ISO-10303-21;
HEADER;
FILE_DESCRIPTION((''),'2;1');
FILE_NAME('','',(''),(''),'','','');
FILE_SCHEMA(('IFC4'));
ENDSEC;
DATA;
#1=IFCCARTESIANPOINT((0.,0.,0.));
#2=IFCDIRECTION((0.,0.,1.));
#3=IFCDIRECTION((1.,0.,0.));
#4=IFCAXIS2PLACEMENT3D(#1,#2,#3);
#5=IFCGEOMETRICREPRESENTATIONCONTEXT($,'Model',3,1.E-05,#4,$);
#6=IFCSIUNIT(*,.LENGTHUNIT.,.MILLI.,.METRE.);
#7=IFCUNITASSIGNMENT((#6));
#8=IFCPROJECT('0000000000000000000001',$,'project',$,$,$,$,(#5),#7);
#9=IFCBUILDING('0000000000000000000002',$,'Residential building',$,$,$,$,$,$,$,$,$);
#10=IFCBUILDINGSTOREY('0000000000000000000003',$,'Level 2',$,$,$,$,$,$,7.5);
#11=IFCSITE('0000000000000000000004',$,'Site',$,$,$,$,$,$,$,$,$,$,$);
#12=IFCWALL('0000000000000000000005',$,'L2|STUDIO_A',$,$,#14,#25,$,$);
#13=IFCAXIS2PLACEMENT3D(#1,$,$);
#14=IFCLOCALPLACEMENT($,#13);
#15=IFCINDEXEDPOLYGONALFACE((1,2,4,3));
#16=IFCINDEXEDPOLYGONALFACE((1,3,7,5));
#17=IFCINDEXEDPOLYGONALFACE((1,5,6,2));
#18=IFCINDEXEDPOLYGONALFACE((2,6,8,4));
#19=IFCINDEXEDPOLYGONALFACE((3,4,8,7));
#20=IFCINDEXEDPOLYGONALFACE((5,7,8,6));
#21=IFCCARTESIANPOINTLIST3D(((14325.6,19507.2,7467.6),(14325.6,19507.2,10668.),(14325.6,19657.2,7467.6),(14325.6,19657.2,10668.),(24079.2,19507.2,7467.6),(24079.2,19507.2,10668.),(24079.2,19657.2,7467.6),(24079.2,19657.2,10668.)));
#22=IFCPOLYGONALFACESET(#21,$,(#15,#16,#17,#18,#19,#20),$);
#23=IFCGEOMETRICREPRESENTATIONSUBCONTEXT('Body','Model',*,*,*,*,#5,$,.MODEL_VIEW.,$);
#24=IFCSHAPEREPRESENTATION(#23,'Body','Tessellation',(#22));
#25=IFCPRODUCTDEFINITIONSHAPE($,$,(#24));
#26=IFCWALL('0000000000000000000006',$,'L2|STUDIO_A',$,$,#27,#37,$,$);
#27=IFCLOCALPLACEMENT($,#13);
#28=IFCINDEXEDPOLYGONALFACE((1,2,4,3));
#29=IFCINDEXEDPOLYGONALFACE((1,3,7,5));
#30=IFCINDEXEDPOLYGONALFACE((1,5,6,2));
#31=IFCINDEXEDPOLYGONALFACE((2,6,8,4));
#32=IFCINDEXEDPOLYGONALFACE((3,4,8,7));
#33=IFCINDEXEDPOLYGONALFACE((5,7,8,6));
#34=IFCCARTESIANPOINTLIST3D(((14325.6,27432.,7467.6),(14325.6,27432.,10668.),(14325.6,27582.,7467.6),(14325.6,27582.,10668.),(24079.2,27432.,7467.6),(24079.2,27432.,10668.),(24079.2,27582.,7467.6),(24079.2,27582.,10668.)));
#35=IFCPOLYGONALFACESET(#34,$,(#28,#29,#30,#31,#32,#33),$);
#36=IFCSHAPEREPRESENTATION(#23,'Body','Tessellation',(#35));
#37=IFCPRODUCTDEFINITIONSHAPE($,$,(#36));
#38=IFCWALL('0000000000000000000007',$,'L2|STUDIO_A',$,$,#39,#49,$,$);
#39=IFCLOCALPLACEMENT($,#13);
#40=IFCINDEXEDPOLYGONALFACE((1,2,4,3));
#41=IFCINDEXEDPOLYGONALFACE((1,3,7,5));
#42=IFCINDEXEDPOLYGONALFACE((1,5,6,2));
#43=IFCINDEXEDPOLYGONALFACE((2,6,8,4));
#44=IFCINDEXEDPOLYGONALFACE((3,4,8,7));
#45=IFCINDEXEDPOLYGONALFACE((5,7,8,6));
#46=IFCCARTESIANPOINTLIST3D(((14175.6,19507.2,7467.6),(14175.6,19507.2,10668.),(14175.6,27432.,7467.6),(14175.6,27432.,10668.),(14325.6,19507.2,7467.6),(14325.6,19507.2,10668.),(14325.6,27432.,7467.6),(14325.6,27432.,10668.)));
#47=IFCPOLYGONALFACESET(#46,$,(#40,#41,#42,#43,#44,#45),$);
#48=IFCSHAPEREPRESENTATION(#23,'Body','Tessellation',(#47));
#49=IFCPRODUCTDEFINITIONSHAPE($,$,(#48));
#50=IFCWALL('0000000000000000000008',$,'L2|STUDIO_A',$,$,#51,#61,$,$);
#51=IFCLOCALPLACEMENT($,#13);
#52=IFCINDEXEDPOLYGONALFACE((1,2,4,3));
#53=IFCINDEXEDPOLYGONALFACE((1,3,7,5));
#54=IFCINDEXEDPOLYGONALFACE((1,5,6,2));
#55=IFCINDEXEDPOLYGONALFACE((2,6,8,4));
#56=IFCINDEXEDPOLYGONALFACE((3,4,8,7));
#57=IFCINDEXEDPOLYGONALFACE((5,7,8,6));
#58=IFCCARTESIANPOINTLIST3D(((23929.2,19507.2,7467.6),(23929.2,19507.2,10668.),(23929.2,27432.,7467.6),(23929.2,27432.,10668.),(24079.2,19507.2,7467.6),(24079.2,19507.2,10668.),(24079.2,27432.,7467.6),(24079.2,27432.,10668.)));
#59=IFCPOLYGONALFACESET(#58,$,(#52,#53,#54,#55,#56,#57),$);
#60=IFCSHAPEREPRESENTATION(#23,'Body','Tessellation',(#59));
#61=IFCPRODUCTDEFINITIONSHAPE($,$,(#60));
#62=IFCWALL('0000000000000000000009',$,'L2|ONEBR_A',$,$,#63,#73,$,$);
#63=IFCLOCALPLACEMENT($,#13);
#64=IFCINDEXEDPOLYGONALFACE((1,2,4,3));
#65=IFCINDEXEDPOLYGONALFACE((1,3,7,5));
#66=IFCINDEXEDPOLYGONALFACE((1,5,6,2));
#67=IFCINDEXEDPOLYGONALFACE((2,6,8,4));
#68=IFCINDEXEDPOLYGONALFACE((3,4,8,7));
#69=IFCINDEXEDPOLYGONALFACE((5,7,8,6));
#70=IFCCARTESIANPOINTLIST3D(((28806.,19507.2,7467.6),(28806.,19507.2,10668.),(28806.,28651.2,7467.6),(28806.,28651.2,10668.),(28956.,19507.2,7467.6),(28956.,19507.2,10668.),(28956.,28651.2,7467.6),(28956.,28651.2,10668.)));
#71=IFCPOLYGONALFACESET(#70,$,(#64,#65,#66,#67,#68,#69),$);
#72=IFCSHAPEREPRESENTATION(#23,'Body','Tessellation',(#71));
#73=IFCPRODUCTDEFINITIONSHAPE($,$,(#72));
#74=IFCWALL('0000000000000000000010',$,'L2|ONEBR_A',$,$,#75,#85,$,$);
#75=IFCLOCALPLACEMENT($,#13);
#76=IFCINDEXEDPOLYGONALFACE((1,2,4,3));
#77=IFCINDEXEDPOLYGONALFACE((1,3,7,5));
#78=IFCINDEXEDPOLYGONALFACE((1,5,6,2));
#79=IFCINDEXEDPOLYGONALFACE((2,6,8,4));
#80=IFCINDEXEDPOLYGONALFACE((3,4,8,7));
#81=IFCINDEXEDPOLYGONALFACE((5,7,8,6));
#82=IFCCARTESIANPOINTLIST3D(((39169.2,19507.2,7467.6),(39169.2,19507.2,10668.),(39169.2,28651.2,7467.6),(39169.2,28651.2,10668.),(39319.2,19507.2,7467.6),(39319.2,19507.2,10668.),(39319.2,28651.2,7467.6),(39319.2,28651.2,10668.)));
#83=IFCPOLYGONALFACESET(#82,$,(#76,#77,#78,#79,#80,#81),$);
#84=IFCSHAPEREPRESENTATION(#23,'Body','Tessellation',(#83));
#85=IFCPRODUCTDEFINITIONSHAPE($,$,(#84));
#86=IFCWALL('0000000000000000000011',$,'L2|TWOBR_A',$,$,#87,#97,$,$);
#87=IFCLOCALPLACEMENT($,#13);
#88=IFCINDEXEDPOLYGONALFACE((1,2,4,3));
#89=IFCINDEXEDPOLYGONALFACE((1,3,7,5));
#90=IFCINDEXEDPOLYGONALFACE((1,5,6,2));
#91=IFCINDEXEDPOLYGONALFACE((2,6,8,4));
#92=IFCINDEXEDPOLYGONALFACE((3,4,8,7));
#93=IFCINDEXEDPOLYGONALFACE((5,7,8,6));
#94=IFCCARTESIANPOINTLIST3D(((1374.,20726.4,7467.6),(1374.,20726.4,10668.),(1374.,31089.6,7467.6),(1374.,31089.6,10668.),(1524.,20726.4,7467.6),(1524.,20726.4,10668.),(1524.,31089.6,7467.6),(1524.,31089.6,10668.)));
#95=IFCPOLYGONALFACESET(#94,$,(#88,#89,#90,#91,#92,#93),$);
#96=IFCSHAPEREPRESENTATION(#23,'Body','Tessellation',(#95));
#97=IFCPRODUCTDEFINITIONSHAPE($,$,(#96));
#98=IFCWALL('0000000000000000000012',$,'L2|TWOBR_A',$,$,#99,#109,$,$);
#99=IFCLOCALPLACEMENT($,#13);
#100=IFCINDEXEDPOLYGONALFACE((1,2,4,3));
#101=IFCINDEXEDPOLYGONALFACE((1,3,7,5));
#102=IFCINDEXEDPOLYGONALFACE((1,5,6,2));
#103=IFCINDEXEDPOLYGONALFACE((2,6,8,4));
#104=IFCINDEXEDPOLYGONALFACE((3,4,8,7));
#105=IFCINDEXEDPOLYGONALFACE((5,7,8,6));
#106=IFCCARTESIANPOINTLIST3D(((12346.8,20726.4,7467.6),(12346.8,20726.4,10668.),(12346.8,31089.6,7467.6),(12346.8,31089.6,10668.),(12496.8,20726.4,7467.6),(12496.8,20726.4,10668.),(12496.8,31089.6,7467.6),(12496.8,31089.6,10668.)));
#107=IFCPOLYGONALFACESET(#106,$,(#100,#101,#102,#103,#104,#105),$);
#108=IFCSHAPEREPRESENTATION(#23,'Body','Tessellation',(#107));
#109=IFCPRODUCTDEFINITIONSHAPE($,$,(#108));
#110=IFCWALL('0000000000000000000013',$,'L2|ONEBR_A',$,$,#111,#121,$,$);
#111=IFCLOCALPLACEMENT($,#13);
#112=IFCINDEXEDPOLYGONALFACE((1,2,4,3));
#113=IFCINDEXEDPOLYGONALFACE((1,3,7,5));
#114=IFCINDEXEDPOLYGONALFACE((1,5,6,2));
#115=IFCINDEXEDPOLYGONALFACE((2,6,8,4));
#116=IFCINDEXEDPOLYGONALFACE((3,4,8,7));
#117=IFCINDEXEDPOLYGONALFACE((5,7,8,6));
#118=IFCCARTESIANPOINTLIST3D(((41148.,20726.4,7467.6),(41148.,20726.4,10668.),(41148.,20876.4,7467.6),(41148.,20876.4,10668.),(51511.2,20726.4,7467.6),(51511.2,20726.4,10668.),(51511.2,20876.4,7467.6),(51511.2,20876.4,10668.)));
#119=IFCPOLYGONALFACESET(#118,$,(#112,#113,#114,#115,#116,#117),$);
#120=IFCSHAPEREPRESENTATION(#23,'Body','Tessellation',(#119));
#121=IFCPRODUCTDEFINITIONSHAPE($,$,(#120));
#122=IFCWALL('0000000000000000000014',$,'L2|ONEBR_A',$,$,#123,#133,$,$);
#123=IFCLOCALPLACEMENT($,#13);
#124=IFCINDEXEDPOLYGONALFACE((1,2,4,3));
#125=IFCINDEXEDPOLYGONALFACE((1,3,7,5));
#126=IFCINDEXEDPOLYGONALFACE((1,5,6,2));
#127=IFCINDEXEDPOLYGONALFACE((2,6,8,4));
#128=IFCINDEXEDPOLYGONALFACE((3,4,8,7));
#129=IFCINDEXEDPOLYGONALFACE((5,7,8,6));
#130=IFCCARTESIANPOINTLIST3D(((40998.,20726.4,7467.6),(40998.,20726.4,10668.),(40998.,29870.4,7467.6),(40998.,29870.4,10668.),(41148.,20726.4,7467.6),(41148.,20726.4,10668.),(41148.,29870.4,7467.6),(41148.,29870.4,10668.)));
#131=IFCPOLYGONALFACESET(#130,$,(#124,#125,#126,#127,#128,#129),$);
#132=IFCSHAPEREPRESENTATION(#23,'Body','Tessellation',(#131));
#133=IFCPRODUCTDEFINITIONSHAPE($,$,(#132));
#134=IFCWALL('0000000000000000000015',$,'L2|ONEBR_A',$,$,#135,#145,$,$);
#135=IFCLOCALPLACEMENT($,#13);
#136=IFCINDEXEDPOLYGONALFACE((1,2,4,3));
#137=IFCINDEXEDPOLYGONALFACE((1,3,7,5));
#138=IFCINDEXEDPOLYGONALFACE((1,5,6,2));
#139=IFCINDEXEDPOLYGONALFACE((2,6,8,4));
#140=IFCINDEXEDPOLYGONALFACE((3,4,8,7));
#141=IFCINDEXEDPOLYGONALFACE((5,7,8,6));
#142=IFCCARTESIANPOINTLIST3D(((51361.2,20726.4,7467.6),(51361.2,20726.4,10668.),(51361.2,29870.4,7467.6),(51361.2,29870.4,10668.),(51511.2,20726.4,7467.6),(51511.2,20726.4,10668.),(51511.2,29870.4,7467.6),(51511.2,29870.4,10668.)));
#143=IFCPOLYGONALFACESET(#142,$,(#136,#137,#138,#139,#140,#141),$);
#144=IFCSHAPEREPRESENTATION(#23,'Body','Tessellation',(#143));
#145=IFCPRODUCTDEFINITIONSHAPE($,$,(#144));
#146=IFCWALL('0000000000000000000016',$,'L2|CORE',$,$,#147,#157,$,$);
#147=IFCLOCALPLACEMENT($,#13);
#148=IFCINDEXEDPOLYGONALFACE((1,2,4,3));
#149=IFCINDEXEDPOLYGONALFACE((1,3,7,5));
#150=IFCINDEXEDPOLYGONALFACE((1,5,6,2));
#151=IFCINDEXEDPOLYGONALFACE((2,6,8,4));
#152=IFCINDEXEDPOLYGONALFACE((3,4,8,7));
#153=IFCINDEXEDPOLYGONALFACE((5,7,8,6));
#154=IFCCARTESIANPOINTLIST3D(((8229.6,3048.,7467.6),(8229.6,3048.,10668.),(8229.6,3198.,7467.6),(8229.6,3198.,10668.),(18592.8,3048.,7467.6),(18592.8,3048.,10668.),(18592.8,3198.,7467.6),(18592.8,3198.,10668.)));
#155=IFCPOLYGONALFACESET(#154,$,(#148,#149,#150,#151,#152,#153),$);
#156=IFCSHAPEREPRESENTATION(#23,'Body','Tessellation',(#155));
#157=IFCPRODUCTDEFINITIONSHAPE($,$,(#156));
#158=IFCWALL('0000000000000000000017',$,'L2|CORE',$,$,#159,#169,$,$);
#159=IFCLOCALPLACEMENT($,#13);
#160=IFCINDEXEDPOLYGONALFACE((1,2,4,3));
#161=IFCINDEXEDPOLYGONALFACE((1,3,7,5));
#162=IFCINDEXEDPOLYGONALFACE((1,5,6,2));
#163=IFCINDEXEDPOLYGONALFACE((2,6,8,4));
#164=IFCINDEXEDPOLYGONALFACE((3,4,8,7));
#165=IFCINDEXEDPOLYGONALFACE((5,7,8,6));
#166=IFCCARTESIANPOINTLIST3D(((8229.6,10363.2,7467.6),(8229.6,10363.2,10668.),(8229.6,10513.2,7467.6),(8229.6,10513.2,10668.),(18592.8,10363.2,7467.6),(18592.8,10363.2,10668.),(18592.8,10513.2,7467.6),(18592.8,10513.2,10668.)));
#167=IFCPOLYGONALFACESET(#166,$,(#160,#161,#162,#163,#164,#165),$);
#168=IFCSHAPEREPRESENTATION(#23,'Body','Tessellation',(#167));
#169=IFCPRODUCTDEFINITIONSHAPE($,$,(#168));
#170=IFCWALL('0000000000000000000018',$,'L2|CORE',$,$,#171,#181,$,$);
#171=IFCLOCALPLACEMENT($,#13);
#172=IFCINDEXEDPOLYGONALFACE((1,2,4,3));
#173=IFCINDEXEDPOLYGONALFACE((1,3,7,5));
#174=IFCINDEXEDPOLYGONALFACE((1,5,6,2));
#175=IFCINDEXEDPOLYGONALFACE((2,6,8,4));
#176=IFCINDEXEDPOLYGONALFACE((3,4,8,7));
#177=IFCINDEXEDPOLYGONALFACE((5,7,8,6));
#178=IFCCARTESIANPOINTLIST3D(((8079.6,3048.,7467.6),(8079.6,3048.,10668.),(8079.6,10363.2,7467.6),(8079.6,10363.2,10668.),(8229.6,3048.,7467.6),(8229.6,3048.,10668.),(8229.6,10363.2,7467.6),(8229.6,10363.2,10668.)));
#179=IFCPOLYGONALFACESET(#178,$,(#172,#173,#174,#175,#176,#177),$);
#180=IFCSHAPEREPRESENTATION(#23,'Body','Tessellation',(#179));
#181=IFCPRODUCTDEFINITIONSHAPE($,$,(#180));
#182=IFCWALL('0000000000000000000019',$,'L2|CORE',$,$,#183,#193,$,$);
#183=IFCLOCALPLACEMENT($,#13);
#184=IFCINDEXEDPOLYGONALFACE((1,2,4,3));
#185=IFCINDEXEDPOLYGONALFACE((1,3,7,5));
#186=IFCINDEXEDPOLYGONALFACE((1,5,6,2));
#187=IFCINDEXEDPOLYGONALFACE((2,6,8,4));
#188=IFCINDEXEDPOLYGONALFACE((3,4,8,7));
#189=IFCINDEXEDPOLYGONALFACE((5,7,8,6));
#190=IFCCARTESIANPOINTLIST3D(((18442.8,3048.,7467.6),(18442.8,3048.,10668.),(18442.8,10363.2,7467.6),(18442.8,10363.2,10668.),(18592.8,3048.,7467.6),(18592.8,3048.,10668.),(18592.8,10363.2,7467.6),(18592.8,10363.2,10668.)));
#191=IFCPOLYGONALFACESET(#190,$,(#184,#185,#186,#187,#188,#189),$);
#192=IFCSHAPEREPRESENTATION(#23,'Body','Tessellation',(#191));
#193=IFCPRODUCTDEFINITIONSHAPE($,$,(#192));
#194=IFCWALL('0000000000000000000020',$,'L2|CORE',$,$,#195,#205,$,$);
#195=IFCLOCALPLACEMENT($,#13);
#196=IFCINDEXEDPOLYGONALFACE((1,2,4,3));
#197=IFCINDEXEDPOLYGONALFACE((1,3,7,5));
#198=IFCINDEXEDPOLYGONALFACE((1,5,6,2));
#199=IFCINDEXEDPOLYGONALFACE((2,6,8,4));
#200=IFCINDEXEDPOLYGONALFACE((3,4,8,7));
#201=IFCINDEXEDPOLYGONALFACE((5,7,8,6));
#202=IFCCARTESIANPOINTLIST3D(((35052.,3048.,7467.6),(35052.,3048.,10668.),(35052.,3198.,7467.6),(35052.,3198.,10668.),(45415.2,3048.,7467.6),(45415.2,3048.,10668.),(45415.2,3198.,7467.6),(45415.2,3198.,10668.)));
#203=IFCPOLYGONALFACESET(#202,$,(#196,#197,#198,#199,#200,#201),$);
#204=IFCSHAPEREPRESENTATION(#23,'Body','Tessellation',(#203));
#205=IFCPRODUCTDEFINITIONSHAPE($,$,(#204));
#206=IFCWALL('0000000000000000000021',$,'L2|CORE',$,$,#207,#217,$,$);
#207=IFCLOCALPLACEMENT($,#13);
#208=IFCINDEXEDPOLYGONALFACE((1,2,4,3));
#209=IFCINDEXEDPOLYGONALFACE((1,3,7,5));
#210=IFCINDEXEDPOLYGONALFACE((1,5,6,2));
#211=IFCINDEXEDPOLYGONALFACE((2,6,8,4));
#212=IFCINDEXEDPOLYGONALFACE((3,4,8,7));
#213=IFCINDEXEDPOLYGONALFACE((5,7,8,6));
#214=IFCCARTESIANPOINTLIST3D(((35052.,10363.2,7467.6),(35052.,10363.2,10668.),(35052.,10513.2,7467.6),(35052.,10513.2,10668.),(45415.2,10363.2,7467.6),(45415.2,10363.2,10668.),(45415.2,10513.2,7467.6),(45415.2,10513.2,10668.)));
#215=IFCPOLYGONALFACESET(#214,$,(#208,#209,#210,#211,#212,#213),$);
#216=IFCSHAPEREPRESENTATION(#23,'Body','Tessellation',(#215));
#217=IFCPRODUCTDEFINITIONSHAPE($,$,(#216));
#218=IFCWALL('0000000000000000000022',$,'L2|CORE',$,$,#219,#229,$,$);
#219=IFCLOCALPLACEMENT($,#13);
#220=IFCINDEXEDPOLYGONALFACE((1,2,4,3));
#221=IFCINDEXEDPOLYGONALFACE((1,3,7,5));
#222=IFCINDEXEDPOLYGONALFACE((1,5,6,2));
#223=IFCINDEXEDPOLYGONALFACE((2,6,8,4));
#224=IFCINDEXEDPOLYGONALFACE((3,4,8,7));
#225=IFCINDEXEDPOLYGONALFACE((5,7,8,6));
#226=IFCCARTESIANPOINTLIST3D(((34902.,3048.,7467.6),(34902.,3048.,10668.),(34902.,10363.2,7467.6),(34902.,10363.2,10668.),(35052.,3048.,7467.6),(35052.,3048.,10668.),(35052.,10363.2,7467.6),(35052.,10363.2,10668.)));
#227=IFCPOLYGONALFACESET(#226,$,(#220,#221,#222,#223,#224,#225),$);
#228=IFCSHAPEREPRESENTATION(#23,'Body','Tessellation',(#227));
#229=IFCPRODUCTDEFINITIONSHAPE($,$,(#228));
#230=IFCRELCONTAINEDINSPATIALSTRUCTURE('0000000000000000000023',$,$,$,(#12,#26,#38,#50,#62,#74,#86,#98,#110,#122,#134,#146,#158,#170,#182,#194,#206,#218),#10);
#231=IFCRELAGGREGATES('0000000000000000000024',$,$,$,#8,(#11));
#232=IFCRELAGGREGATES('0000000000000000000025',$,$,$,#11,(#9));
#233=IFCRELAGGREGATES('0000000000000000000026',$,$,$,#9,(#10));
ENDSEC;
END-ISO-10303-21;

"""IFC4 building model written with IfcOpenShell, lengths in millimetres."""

from ifc_helpers import new_model, si_unit, frame, origin_with_axes, place, context, subcontext, project, spatial, indexed_curve, outline, extrude, element, save


model = new_model("IFC4")

# Units and contexts
model_context = context("Model", 3, precision=1e-05, world=origin_with_axes())
body_context = subcontext(model_context, "Body", "Model", "MODEL_VIEW")
ifc_project = project(units=[si_unit("LENGTHUNIT", "METRE", prefix="MILLI")], contexts=[model_context])

# Site, building, storey
site = spatial("IfcSite", under=ifc_project, Name="Site")
building = spatial("IfcBuilding", under=site, Name="Residential building")
storey = spatial("IfcBuildingStorey", under=building, Name="Level 2", Elevation=7.5)

# Walls
for number, where, z_axis, x_axis, name in (
    (1, (14325.6, 19507.2, 7467.6), (0.0, 0.0, 1.0), (1.0, 0.0, 0.0), "L2|STUDIO_A"),
    (2, (14325.6, 27432.0, 7467.6), (0.0, 0.0, 1.0), (1.0, 0.0, 0.0), "L2|STUDIO_A"),
):
    element("IfcWall", number, at=place(None, frame(where, z_axis=z_axis, x_axis=x_axis)), inside=storey, Name=name, context=body_context, shape_type="SweptSolid", body=[
        extrude(outline(indexed_curve([(0.0, 0.0), (0.0, 150.0), (9753.6, 150.0), (9753.6, 0.0), (0.0, 0.0)], self_intersect=False)), origin_with_axes(), (0.0, 0.0, 1.0), 3200.4),
    ])
for number, where, z_axis, x_axis, name in (
    (3, (14325.6, 19507.2, 7467.6), (0.0, 0.0, 1.0), (0.0, 1.0, 0.0), "L2|STUDIO_A"),
    (4, (24079.2, 19507.2, 7467.6), (0.0, 0.0, 1.0), (0.0, 1.0, 0.0), "L2|STUDIO_A"),
):
    element("IfcWall", number, at=place(None, frame(where, z_axis=z_axis, x_axis=x_axis)), inside=storey, Name=name, context=body_context, shape_type="SweptSolid", body=[
        extrude(outline(indexed_curve([(0.0, 0.0), (0.0, 150.0), (7924.8, 150.0), (7924.8, 0.0), (0.0, 0.0)], self_intersect=False)), origin_with_axes(), (0.0, 0.0, 1.0), 3200.4),
    ])
for number, where, z_axis, x_axis, name in (
    (5, (28956.0, 19507.2, 7467.6), (0.0, 0.0, 1.0), (0.0, 1.0, 0.0), "L2|ONEBR_A"),
    (6, (39319.2, 19507.2, 7467.6), (0.0, 0.0, 1.0), (0.0, 1.0, 0.0), "L2|ONEBR_A"),
):
    element("IfcWall", number, at=place(None, frame(where, z_axis=z_axis, x_axis=x_axis)), inside=storey, Name=name, context=body_context, shape_type="SweptSolid", body=[
        extrude(outline(indexed_curve([(0.0, 0.0), (0.0, 150.0), (9144.0, 150.0), (9144.0, 0.0), (0.0, 0.0)], self_intersect=False)), origin_with_axes(), (0.0, 0.0, 1.0), 3200.4),
    ])
for number, where, z_axis, x_axis, name in (
    (7, (1524.0, 20726.4, 7467.6), (0.0, 0.0, 1.0), (0.0, 1.0, 0.0), "L2|TWOBR_A"),
    (8, (12496.8, 20726.4, 7467.6), (0.0, 0.0, 1.0), (0.0, 1.0, 0.0), "L2|TWOBR_A"),
    (9, (41148.0, 20726.4, 7467.6), (0.0, 0.0, 1.0), (1.0, 0.0, 0.0), "L2|ONEBR_A"),
):
    element("IfcWall", number, at=place(None, frame(where, z_axis=z_axis, x_axis=x_axis)), inside=storey, Name=name, context=body_context, shape_type="SweptSolid", body=[
        extrude(outline(indexed_curve([(0.0, 0.0), (0.0, 150.0), (10363.2, 150.0), (10363.2, 0.0), (0.0, 0.0)], self_intersect=False)), origin_with_axes(), (0.0, 0.0, 1.0), 3200.4),
    ])
for number, where, z_axis, x_axis, name in (
    (10, (41148.0, 20726.4, 7467.6), (0.0, 0.0, 1.0), (0.0, 1.0, 0.0), "L2|ONEBR_A"),
    (11, (51511.2, 20726.4, 7467.6), (0.0, 0.0, 1.0), (0.0, 1.0, 0.0), "L2|ONEBR_A"),
):
    element("IfcWall", number, at=place(None, frame(where, z_axis=z_axis, x_axis=x_axis)), inside=storey, Name=name, context=body_context, shape_type="SweptSolid", body=[
        extrude(outline(indexed_curve([(0.0, 0.0), (0.0, 150.0), (9144.0, 150.0), (9144.0, 0.0), (0.0, 0.0)], self_intersect=False)), origin_with_axes(), (0.0, 0.0, 1.0), 3200.4),
    ])
for number, where, z_axis, x_axis, name in (
    (12, (8229.6, 3048.0, 7467.6), (0.0, 0.0, 1.0), (1.0, 0.0, 0.0), "L2|CORE"),
    (13, (8229.6, 10363.2, 7467.6), (0.0, 0.0, 1.0), (1.0, 0.0, 0.0), "L2|CORE"),
):
    element("IfcWall", number, at=place(None, frame(where, z_axis=z_axis, x_axis=x_axis)), inside=storey, Name=name, context=body_context, shape_type="SweptSolid", body=[
        extrude(outline(indexed_curve([(0.0, 0.0), (0.0, 150.0), (10363.2, 150.0), (10363.2, 0.0), (0.0, 0.0)], self_intersect=False)), origin_with_axes(), (0.0, 0.0, 1.0), 3200.4),
    ])
for number, where, z_axis, x_axis, name in (
    (14, (8229.6, 3048.0, 7467.6), (0.0, 0.0, 1.0), (0.0, 1.0, 0.0), "L2|CORE"),
    (15, (18592.8, 3048.0, 7467.6), (0.0, 0.0, 1.0), (0.0, 1.0, 0.0), "L2|CORE"),
):
    element("IfcWall", number, at=place(None, frame(where, z_axis=z_axis, x_axis=x_axis)), inside=storey, Name=name, context=body_context, shape_type="SweptSolid", body=[
        extrude(outline(indexed_curve([(0.0, 0.0), (0.0, 150.0), (7315.2, 150.0), (7315.2, 0.0), (0.0, 0.0)], self_intersect=False)), origin_with_axes(), (0.0, 0.0, 1.0), 3200.4),
    ])
for number, where, z_axis, x_axis, name in (
    (16, (35052.0, 3048.0, 7467.6), (0.0, 0.0, 1.0), (1.0, 0.0, 0.0), "L2|CORE"),
    (17, (35052.0, 10363.2, 7467.6), (0.0, 0.0, 1.0), (1.0, 0.0, 0.0), "L2|CORE"),
):
    element("IfcWall", number, at=place(None, frame(where, z_axis=z_axis, x_axis=x_axis)), inside=storey, Name=name, context=body_context, shape_type="SweptSolid", body=[
        extrude(outline(indexed_curve([(0.0, 0.0), (0.0, 150.0), (10363.2, 150.0), (10363.2, 0.0), (0.0, 0.0)], self_intersect=False)), origin_with_axes(), (0.0, 0.0, 1.0), 3200.4),
    ])
for number, where, z_axis, x_axis, name in (
    (18, (35052.0, 3048.0, 7467.6), (0.0, 0.0, 1.0), (0.0, 1.0, 0.0), "L2|CORE"),
):
    element("IfcWall", number, at=place(None, frame(where, z_axis=z_axis, x_axis=x_axis)), inside=storey, Name=name, context=body_context, shape_type="SweptSolid", body=[
        extrude(outline(indexed_curve([(0.0, 0.0), (0.0, 150.0), (7315.2, 150.0), (7315.2, 0.0), (0.0, 0.0)], self_intersect=False)), origin_with_axes(), (0.0, 0.0, 1.0), 3200.4),
    ])

save(model, "model.ifc")
